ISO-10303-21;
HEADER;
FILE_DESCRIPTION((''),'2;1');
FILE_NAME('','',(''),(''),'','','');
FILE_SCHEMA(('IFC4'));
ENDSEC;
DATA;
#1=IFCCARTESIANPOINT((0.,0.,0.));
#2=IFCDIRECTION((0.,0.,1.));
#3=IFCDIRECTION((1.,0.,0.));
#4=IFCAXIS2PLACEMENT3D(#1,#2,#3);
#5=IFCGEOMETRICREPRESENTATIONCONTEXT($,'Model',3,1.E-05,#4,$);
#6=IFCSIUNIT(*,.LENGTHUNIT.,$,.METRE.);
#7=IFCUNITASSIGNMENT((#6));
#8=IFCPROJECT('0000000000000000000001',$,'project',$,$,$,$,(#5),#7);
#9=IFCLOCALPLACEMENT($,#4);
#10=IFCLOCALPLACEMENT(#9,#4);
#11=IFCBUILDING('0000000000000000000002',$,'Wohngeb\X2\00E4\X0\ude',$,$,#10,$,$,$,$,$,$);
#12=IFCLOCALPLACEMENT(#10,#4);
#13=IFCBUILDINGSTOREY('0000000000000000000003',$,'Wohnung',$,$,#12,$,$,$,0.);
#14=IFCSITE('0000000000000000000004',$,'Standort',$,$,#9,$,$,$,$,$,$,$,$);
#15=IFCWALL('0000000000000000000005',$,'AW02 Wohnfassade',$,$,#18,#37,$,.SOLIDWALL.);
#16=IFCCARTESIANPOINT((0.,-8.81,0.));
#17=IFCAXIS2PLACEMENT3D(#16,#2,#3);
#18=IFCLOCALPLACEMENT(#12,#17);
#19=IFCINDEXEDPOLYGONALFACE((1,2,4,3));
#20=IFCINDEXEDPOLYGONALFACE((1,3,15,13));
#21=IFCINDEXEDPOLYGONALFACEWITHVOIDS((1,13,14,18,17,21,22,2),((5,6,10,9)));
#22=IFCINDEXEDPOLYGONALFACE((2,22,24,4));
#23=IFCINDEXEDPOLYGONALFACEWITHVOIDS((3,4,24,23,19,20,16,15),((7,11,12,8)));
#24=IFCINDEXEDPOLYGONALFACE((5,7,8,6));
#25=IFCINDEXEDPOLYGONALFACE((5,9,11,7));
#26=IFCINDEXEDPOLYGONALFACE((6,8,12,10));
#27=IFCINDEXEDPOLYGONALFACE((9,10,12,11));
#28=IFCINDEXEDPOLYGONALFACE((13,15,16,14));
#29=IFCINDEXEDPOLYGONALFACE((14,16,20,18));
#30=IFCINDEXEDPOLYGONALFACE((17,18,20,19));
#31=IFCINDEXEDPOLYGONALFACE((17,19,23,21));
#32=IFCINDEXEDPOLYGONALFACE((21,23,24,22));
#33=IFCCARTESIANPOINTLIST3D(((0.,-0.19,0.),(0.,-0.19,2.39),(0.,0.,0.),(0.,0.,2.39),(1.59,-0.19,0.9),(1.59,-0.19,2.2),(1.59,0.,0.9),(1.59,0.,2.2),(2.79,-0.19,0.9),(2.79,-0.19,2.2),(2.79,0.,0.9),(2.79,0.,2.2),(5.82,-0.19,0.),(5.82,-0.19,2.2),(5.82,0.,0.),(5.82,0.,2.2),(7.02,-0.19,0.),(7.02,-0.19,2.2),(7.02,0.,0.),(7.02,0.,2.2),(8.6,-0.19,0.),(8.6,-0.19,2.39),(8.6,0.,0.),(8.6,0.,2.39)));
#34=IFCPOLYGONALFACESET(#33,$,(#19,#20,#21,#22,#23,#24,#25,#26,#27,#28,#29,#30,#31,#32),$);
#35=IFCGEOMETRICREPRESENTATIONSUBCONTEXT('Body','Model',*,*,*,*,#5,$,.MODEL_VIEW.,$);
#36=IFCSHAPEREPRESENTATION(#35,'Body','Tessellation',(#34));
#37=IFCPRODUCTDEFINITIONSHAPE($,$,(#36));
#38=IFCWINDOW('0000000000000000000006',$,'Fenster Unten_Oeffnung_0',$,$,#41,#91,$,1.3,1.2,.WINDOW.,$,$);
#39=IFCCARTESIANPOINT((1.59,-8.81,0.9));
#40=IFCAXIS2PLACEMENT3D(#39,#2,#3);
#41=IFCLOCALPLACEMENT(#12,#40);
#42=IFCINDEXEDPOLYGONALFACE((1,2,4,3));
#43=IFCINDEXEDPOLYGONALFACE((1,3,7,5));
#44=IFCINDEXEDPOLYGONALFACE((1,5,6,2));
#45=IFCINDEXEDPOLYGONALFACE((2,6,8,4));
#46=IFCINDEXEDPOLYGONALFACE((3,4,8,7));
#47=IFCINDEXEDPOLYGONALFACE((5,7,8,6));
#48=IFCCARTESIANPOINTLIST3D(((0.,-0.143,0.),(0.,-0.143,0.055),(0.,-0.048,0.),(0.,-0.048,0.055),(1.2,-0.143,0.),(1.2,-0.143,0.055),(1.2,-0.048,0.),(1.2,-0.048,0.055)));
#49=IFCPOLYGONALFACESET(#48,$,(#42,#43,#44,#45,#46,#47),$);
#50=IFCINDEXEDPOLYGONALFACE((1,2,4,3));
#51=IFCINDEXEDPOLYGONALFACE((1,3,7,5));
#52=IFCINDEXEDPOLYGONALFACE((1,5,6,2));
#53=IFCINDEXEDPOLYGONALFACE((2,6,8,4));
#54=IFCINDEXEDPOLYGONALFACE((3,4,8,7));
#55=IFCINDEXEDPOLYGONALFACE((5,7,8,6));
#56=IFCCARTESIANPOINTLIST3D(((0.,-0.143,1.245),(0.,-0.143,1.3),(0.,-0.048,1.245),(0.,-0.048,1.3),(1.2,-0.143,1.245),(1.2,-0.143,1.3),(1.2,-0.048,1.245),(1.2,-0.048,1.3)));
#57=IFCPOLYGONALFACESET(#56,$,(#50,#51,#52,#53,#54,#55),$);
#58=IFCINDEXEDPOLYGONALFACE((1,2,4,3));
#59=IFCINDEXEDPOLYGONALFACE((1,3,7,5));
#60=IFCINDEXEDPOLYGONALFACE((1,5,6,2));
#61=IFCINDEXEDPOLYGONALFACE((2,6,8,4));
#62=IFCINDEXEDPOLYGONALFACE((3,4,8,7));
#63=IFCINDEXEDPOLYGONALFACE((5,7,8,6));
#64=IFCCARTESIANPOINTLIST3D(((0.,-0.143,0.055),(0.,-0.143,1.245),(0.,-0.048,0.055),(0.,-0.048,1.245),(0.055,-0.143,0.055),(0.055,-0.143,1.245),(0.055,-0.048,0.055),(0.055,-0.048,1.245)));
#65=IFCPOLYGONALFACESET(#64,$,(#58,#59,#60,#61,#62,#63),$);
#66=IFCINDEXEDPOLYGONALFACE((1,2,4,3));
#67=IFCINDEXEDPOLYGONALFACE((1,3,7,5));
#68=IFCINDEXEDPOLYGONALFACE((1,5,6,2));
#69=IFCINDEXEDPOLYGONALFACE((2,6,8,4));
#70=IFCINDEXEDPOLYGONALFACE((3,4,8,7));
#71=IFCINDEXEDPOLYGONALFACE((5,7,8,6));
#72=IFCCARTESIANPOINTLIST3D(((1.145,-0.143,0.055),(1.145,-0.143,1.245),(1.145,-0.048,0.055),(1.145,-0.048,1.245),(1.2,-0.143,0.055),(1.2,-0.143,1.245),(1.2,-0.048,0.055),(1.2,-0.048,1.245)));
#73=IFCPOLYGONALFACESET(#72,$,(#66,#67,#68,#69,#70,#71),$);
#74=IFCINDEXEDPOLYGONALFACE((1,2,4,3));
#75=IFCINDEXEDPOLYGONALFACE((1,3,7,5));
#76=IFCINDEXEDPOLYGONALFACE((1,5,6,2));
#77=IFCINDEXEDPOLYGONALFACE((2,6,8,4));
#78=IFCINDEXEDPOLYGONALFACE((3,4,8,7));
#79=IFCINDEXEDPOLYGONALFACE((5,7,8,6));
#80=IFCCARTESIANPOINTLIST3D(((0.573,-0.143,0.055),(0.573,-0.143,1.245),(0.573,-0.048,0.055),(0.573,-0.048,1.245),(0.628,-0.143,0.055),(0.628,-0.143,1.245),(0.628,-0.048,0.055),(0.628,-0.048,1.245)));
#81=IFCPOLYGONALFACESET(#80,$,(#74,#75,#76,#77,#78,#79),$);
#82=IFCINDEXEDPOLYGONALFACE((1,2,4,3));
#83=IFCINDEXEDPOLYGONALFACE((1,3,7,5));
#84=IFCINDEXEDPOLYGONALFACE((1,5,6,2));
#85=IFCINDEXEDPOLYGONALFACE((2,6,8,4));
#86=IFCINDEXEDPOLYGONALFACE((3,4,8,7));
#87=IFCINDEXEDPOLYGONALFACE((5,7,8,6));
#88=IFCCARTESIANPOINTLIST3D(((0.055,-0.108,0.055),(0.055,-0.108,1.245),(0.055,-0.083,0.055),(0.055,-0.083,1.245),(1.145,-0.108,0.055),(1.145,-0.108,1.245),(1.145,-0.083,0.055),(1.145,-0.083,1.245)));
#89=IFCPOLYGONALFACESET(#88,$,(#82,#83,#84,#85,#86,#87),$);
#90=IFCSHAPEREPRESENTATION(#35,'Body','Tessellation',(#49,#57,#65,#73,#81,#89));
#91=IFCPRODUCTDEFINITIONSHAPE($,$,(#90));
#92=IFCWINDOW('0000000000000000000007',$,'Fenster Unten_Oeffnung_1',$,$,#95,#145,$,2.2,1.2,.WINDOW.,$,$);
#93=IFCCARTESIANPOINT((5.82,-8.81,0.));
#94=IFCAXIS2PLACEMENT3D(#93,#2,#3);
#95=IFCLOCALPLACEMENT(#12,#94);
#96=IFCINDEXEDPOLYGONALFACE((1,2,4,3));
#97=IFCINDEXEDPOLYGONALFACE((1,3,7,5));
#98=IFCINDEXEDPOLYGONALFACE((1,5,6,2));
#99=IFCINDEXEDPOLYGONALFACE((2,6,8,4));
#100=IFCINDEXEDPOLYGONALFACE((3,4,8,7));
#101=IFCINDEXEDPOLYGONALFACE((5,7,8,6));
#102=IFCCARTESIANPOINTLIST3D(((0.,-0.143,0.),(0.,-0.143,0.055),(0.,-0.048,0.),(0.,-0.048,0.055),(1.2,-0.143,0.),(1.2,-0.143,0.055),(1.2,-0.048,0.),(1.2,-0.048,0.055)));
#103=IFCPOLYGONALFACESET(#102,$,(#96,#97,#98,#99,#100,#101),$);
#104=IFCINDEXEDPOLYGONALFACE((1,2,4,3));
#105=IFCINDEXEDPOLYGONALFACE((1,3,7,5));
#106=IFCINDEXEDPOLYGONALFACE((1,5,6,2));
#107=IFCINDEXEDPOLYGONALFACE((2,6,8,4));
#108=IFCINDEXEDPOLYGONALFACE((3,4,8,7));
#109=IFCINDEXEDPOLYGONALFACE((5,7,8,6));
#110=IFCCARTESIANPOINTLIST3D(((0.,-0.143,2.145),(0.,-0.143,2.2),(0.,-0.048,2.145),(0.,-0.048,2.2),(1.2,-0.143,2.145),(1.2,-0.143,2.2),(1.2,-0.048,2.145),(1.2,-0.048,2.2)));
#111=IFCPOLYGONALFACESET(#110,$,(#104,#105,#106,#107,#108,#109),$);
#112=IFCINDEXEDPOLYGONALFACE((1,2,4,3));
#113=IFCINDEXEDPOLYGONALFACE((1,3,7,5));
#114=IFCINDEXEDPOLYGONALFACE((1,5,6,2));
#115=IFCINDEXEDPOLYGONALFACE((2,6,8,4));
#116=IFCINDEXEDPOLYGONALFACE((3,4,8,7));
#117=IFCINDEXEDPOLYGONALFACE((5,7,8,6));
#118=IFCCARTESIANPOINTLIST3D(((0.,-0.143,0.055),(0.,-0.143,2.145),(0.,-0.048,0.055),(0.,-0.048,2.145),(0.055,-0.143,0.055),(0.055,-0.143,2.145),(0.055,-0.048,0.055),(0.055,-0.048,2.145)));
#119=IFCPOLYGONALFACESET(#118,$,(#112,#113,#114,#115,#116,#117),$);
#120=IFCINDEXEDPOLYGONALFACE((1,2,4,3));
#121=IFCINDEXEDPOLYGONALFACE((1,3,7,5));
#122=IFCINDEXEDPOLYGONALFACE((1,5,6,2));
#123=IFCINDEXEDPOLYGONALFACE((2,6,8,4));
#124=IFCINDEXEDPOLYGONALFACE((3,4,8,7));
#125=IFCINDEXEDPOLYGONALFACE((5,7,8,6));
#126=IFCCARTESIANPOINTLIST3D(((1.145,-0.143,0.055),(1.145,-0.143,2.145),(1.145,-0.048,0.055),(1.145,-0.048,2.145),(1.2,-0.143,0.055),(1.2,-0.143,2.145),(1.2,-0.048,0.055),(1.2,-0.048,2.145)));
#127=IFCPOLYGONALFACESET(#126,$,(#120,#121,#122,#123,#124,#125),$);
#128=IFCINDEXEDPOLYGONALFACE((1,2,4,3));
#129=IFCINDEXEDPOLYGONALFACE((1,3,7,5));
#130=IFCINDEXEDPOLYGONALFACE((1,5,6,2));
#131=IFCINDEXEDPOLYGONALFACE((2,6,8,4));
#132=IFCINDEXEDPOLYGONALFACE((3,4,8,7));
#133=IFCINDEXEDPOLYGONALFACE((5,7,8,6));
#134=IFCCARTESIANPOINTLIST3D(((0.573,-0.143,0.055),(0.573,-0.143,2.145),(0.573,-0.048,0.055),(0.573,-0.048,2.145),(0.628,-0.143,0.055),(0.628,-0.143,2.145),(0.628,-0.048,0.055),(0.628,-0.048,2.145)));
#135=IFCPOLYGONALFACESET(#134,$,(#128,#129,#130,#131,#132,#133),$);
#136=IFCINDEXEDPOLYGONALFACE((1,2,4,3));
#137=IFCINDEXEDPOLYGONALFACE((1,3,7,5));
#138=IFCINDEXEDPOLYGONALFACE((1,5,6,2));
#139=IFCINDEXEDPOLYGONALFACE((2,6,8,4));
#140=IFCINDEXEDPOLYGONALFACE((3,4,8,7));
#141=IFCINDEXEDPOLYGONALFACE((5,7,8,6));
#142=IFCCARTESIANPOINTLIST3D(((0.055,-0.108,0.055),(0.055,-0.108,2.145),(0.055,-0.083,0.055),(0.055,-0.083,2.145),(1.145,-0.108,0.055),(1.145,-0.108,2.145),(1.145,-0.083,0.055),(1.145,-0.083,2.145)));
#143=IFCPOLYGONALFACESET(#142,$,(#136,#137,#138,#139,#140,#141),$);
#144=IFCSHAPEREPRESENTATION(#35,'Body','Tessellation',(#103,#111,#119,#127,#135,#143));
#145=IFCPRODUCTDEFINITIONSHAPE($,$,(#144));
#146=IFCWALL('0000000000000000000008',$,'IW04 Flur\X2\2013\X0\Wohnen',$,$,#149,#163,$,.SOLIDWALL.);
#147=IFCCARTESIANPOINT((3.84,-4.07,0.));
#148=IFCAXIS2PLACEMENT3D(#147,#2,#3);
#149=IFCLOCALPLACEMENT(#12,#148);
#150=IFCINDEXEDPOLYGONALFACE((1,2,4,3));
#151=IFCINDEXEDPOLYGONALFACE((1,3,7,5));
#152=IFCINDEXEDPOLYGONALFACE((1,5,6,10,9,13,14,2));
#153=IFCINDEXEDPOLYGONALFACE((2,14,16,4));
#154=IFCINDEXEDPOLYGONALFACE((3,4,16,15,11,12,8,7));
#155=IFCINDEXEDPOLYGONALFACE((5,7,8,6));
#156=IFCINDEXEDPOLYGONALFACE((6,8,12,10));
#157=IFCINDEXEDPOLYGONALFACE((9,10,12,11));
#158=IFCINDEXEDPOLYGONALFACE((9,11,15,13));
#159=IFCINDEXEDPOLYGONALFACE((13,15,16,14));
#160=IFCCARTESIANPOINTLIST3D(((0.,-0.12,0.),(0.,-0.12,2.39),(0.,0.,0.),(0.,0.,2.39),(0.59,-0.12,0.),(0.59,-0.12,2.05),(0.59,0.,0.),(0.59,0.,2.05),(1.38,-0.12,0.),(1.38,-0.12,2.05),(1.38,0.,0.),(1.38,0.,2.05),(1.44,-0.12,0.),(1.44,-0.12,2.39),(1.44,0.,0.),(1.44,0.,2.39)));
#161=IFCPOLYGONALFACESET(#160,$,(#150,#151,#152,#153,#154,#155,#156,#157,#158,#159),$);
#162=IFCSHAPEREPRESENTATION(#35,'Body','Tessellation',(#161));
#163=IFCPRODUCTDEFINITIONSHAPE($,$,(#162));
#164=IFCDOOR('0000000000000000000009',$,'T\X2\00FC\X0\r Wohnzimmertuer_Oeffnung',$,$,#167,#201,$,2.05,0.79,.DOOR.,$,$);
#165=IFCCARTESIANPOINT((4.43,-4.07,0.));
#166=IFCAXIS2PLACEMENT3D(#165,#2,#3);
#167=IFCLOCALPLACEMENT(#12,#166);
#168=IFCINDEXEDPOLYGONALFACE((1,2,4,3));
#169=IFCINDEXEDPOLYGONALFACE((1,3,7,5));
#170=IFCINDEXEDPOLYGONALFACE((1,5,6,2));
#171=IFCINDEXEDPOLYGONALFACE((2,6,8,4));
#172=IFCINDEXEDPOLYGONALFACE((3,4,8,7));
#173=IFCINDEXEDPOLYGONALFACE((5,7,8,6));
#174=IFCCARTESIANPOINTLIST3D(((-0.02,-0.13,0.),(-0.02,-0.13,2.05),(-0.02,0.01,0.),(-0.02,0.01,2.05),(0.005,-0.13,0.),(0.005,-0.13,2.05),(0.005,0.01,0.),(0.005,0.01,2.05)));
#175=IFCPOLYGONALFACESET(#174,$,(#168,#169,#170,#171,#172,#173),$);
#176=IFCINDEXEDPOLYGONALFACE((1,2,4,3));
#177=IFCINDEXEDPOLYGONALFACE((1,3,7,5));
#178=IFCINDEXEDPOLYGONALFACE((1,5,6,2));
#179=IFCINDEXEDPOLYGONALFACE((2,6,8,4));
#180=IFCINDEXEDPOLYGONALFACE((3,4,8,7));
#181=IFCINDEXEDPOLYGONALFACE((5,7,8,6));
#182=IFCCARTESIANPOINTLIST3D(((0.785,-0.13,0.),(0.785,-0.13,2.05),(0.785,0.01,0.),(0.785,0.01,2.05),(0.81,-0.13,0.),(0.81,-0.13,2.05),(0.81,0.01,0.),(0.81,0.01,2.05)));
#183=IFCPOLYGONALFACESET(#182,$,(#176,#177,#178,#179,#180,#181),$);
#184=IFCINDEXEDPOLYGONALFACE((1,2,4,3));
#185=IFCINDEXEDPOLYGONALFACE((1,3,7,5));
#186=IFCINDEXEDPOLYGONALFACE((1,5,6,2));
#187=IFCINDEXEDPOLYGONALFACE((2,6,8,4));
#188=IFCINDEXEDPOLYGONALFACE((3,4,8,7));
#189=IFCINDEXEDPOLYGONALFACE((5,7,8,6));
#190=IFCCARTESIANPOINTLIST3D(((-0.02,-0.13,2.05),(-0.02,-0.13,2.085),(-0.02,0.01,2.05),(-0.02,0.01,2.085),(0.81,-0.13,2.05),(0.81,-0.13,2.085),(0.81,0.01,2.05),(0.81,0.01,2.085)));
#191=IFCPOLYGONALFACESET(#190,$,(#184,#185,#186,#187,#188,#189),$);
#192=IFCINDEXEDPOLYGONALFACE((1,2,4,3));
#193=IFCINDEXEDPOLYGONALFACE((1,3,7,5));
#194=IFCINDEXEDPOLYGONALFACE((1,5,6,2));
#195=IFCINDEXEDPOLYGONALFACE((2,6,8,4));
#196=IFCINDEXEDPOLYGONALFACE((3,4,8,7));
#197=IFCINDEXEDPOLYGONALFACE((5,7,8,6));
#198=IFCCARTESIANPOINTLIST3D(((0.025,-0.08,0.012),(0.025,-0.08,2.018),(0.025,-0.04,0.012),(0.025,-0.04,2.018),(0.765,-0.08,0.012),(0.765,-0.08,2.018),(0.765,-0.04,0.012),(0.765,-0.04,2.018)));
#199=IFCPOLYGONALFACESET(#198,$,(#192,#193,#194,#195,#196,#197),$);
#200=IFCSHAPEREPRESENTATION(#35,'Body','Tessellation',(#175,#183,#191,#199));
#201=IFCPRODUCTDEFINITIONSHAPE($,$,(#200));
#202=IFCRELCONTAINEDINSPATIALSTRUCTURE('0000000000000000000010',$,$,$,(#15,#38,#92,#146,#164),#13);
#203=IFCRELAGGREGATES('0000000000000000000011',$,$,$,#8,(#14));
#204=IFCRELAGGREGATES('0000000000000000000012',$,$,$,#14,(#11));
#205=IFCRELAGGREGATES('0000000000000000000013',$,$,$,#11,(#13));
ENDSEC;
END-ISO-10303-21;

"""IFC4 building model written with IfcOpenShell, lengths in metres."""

from ifc_helpers import new_model, si_unit, frame, origin, origin_with_axes, place, context, subcontext, project, spatial, polyline, outline, extrude, element, fill, save


model = new_model("IFC4")

# Units and contexts
model_context = context("Model", 3, precision=1e-05, world=origin_with_axes())
body_context = subcontext(model_context, "Body", "Model", "MODEL_VIEW")
ifc_project = project(units=[si_unit("LENGTHUNIT", "METRE")], contexts=[model_context])

# Site, building, storey
site_placement = place(None, origin_with_axes())
site = spatial("IfcSite", under=ifc_project, at=site_placement, Name="Standort")
building_placement = place(site_placement, origin_with_axes())
building = spatial("IfcBuilding", under=site, at=building_placement, Name="Wohngebäude")
storey_placement = place(building_placement, origin_with_axes())
storey = spatial("IfcBuildingStorey", under=building, at=storey_placement, Name="Wohnung", Elevation=0.0)

# Wall, openings, windows
wall_1_placement = place(storey_placement, frame((0.0, -8.81, 0.0), z_axis=(0.0, 0.0, 1.0), x_axis=(1.0, 0.0, 0.0)))
wall_1 = element("IfcWall", 1, at=wall_1_placement, inside=storey, Name="AW02 Wohnfassade", PredefinedType="SOLIDWALL", context=body_context, shape_type="SweptSolid", body=[
    extrude(outline(polyline([(0.0, 0.0), (0.0, -0.19), (8.6, -0.19), (8.6, 0.0), (0.0, 0.0)])), origin(), (0.0, 0.0, 1.0), 2.39),
])
opening_1_placement = place(wall_1_placement, frame((1.59, 0.0, 0.9), z_axis=(0.0, 0.0, 1.0), x_axis=(1.0, 0.0, 0.0)))
opening_1 = element("IfcOpeningElement", 2, at=opening_1_placement, cuts=wall_1, PredefinedType="OPENING", context=body_context, shape_type="SweptSolid", body=[
    extrude(outline(polyline([(0.0, 0.005), (0.0, -0.195), (1.2, -0.195), (1.2, 0.005), (0.0, 0.005)])), origin(), (0.0, 0.0, 1.0), 1.3),
])
opening_2_placement = place(wall_1_placement, frame((5.82, 0.0, 0.0), z_axis=(0.0, 0.0, 1.0), x_axis=(1.0, 0.0, 0.0)))
opening_2 = element("IfcOpeningElement", 3, at=opening_2_placement, cuts=wall_1, PredefinedType="OPENING", context=body_context, shape_type="SweptSolid", body=[
    extrude(outline(polyline([(0.0, 0.005), (0.0, -0.195), (1.2, -0.195), (1.2, 0.005), (0.0, 0.005)])), origin(), (0.0, 0.0, 1.0), 2.2),
])
window_1_placement = place(storey_placement, frame((1.59, -8.81, 0.9), z_axis=(0.0, 0.0, 1.0), x_axis=(1.0, 0.0, 0.0)))
window_1 = element("IfcWindow", 4, at=window_1_placement, inside=storey, Name="Fenster Unten_Oeffnung_0", OverallHeight=1.3, OverallWidth=1.2, PredefinedType="WINDOW", context=body_context, shape_type="SweptSolid", body=[
    extrude(outline(polyline([(0.0, -0.048), (0.0, -0.143), (1.2, -0.143), (1.2, -0.048), (0.0, -0.048)])), origin(), (0.0, 0.0, 1.0), 0.055),
    extrude(outline(polyline([(0.0, -0.048), (0.0, -0.143), (1.2, -0.143), (1.2, -0.048), (0.0, -0.048)])), frame((0.0, 0.0, 1.245)), (0.0, 0.0, 1.0), 0.055),
    extrude(outline(polyline([(0.0, -0.048), (0.0, -0.143), (0.055, -0.143), (0.055, -0.048), (0.0, -0.048)])), frame((0.0, 0.0, 0.055)), (0.0, 0.0, 1.0), 1.19),
    extrude(outline(polyline([(1.145, -0.048), (1.145, -0.143), (1.2, -0.143), (1.2, -0.048), (1.145, -0.048)])), frame((0.0, 0.0, 0.055)), (0.0, 0.0, 1.0), 1.19),
    extrude(outline(polyline([(0.573, -0.048), (0.573, -0.143), (0.628, -0.143), (0.628, -0.048), (0.573, -0.048)])), frame((0.0, 0.0, 0.055)), (0.0, 0.0, 1.0), 1.19),
    extrude(outline(polyline([(0.055, -0.083), (0.055, -0.108), (1.145, -0.108), (1.145, -0.083), (0.055, -0.083)])), frame((0.0, 0.0, 0.055)), (0.0, 0.0, 1.0), 1.19),
])
fill(opening_1, window_1)
window_2_placement = place(storey_placement, frame((5.82, -8.81, 0.0), z_axis=(0.0, 0.0, 1.0), x_axis=(1.0, 0.0, 0.0)))
window_2 = element("IfcWindow", 5, at=window_2_placement, inside=storey, Name="Fenster Unten_Oeffnung_1", OverallHeight=2.2, OverallWidth=1.2, PredefinedType="WINDOW", context=body_context, shape_type="SweptSolid", body=[
    extrude(outline(polyline([(0.0, -0.048), (0.0, -0.143), (1.2, -0.143), (1.2, -0.048), (0.0, -0.048)])), origin(), (0.0, 0.0, 1.0), 0.055),
    extrude(outline(polyline([(0.0, -0.048), (0.0, -0.143), (1.2, -0.143), (1.2, -0.048), (0.0, -0.048)])), frame((0.0, 0.0, 2.145)), (0.0, 0.0, 1.0), 0.055),
    extrude(outline(polyline([(0.0, -0.048), (0.0, -0.143), (0.055, -0.143), (0.055, -0.048), (0.0, -0.048)])), frame((0.0, 0.0, 0.055)), (0.0, 0.0, 1.0), 2.09),
    extrude(outline(polyline([(1.145, -0.048), (1.145, -0.143), (1.2, -0.143), (1.2, -0.048), (1.145, -0.048)])), frame((0.0, 0.0, 0.055)), (0.0, 0.0, 1.0), 2.09),
    extrude(outline(polyline([(0.573, -0.048), (0.573, -0.143), (0.628, -0.143), (0.628, -0.048), (0.573, -0.048)])), frame((0.0, 0.0, 0.055)), (0.0, 0.0, 1.0), 2.09),
    extrude(outline(polyline([(0.055, -0.083), (0.055, -0.108), (1.145, -0.108), (1.145, -0.083), (0.055, -0.083)])), frame((0.0, 0.0, 0.055)), (0.0, 0.0, 1.0), 2.09),
])
fill(opening_2, window_2)

# Wall, opening, door
wall_2_placement = place(storey_placement, frame((3.84, -4.07, 0.0), z_axis=(0.0, 0.0, 1.0), x_axis=(1.0, 0.0, 0.0)))
wall_2 = element("IfcWall", 6, at=wall_2_placement, inside=storey, Name="IW04 Flur–Wohnen", PredefinedType="SOLIDWALL", context=body_context, shape_type="SweptSolid", body=[
    extrude(outline(polyline([(0.0, 0.0), (0.0, -0.12), (1.44, -0.12), (1.44, 0.0), (0.0, 0.0)])), origin(), (0.0, 0.0, 1.0), 2.39),
])
opening_3_placement = place(wall_2_placement, frame((0.59, 0.0, 0.0), z_axis=(0.0, 0.0, 1.0), x_axis=(1.0, 0.0, 0.0)))
opening_3 = element("IfcOpeningElement", 7, at=opening_3_placement, cuts=wall_2, PredefinedType="OPENING", context=body_context, shape_type="SweptSolid", body=[
    extrude(outline(polyline([(0.0, 0.005), (0.0, -0.125), (0.79, -0.125), (0.79, 0.005), (0.0, 0.005)])), origin(), (0.0, 0.0, 1.0), 2.05),
])
door_1_placement = place(storey_placement, frame((4.43, -4.07, 0.0), z_axis=(0.0, 0.0, 1.0), x_axis=(1.0, 0.0, 0.0)))
door_1 = element("IfcDoor", 8, at=door_1_placement, inside=storey, Name="Tür Wohnzimmertuer_Oeffnung", OverallHeight=2.05, OverallWidth=0.79, PredefinedType="DOOR", context=body_context, shape_type="SweptSolid", body=[
    extrude(outline(polyline([(-0.02, 0.01), (-0.02, -0.13), (0.005, -0.13), (0.005, 0.01), (-0.02, 0.01)])), origin(), (0.0, 0.0, 1.0), 2.05),
    extrude(outline(polyline([(0.785, 0.01), (0.785, -0.13), (0.81, -0.13), (0.81, 0.01), (0.785, 0.01)])), origin(), (0.0, 0.0, 1.0), 2.05),
    extrude(outline(polyline([(-0.02, 0.01), (-0.02, -0.13), (0.81, -0.13), (0.81, 0.01), (-0.02, 0.01)])), frame((0.0, 0.0, 2.05)), (0.0, 0.0, 1.0), 0.035),
    extrude(outline(polyline([(0.025, -0.04), (0.025, -0.08), (0.765, -0.08), (0.765, -0.04), (0.025, -0.04)])), frame((0.0, 0.0, 0.012)), (0.0, 0.0, 1.0), 2.006),
])
fill(opening_3, door_1)

save(model, "model.ifc")
